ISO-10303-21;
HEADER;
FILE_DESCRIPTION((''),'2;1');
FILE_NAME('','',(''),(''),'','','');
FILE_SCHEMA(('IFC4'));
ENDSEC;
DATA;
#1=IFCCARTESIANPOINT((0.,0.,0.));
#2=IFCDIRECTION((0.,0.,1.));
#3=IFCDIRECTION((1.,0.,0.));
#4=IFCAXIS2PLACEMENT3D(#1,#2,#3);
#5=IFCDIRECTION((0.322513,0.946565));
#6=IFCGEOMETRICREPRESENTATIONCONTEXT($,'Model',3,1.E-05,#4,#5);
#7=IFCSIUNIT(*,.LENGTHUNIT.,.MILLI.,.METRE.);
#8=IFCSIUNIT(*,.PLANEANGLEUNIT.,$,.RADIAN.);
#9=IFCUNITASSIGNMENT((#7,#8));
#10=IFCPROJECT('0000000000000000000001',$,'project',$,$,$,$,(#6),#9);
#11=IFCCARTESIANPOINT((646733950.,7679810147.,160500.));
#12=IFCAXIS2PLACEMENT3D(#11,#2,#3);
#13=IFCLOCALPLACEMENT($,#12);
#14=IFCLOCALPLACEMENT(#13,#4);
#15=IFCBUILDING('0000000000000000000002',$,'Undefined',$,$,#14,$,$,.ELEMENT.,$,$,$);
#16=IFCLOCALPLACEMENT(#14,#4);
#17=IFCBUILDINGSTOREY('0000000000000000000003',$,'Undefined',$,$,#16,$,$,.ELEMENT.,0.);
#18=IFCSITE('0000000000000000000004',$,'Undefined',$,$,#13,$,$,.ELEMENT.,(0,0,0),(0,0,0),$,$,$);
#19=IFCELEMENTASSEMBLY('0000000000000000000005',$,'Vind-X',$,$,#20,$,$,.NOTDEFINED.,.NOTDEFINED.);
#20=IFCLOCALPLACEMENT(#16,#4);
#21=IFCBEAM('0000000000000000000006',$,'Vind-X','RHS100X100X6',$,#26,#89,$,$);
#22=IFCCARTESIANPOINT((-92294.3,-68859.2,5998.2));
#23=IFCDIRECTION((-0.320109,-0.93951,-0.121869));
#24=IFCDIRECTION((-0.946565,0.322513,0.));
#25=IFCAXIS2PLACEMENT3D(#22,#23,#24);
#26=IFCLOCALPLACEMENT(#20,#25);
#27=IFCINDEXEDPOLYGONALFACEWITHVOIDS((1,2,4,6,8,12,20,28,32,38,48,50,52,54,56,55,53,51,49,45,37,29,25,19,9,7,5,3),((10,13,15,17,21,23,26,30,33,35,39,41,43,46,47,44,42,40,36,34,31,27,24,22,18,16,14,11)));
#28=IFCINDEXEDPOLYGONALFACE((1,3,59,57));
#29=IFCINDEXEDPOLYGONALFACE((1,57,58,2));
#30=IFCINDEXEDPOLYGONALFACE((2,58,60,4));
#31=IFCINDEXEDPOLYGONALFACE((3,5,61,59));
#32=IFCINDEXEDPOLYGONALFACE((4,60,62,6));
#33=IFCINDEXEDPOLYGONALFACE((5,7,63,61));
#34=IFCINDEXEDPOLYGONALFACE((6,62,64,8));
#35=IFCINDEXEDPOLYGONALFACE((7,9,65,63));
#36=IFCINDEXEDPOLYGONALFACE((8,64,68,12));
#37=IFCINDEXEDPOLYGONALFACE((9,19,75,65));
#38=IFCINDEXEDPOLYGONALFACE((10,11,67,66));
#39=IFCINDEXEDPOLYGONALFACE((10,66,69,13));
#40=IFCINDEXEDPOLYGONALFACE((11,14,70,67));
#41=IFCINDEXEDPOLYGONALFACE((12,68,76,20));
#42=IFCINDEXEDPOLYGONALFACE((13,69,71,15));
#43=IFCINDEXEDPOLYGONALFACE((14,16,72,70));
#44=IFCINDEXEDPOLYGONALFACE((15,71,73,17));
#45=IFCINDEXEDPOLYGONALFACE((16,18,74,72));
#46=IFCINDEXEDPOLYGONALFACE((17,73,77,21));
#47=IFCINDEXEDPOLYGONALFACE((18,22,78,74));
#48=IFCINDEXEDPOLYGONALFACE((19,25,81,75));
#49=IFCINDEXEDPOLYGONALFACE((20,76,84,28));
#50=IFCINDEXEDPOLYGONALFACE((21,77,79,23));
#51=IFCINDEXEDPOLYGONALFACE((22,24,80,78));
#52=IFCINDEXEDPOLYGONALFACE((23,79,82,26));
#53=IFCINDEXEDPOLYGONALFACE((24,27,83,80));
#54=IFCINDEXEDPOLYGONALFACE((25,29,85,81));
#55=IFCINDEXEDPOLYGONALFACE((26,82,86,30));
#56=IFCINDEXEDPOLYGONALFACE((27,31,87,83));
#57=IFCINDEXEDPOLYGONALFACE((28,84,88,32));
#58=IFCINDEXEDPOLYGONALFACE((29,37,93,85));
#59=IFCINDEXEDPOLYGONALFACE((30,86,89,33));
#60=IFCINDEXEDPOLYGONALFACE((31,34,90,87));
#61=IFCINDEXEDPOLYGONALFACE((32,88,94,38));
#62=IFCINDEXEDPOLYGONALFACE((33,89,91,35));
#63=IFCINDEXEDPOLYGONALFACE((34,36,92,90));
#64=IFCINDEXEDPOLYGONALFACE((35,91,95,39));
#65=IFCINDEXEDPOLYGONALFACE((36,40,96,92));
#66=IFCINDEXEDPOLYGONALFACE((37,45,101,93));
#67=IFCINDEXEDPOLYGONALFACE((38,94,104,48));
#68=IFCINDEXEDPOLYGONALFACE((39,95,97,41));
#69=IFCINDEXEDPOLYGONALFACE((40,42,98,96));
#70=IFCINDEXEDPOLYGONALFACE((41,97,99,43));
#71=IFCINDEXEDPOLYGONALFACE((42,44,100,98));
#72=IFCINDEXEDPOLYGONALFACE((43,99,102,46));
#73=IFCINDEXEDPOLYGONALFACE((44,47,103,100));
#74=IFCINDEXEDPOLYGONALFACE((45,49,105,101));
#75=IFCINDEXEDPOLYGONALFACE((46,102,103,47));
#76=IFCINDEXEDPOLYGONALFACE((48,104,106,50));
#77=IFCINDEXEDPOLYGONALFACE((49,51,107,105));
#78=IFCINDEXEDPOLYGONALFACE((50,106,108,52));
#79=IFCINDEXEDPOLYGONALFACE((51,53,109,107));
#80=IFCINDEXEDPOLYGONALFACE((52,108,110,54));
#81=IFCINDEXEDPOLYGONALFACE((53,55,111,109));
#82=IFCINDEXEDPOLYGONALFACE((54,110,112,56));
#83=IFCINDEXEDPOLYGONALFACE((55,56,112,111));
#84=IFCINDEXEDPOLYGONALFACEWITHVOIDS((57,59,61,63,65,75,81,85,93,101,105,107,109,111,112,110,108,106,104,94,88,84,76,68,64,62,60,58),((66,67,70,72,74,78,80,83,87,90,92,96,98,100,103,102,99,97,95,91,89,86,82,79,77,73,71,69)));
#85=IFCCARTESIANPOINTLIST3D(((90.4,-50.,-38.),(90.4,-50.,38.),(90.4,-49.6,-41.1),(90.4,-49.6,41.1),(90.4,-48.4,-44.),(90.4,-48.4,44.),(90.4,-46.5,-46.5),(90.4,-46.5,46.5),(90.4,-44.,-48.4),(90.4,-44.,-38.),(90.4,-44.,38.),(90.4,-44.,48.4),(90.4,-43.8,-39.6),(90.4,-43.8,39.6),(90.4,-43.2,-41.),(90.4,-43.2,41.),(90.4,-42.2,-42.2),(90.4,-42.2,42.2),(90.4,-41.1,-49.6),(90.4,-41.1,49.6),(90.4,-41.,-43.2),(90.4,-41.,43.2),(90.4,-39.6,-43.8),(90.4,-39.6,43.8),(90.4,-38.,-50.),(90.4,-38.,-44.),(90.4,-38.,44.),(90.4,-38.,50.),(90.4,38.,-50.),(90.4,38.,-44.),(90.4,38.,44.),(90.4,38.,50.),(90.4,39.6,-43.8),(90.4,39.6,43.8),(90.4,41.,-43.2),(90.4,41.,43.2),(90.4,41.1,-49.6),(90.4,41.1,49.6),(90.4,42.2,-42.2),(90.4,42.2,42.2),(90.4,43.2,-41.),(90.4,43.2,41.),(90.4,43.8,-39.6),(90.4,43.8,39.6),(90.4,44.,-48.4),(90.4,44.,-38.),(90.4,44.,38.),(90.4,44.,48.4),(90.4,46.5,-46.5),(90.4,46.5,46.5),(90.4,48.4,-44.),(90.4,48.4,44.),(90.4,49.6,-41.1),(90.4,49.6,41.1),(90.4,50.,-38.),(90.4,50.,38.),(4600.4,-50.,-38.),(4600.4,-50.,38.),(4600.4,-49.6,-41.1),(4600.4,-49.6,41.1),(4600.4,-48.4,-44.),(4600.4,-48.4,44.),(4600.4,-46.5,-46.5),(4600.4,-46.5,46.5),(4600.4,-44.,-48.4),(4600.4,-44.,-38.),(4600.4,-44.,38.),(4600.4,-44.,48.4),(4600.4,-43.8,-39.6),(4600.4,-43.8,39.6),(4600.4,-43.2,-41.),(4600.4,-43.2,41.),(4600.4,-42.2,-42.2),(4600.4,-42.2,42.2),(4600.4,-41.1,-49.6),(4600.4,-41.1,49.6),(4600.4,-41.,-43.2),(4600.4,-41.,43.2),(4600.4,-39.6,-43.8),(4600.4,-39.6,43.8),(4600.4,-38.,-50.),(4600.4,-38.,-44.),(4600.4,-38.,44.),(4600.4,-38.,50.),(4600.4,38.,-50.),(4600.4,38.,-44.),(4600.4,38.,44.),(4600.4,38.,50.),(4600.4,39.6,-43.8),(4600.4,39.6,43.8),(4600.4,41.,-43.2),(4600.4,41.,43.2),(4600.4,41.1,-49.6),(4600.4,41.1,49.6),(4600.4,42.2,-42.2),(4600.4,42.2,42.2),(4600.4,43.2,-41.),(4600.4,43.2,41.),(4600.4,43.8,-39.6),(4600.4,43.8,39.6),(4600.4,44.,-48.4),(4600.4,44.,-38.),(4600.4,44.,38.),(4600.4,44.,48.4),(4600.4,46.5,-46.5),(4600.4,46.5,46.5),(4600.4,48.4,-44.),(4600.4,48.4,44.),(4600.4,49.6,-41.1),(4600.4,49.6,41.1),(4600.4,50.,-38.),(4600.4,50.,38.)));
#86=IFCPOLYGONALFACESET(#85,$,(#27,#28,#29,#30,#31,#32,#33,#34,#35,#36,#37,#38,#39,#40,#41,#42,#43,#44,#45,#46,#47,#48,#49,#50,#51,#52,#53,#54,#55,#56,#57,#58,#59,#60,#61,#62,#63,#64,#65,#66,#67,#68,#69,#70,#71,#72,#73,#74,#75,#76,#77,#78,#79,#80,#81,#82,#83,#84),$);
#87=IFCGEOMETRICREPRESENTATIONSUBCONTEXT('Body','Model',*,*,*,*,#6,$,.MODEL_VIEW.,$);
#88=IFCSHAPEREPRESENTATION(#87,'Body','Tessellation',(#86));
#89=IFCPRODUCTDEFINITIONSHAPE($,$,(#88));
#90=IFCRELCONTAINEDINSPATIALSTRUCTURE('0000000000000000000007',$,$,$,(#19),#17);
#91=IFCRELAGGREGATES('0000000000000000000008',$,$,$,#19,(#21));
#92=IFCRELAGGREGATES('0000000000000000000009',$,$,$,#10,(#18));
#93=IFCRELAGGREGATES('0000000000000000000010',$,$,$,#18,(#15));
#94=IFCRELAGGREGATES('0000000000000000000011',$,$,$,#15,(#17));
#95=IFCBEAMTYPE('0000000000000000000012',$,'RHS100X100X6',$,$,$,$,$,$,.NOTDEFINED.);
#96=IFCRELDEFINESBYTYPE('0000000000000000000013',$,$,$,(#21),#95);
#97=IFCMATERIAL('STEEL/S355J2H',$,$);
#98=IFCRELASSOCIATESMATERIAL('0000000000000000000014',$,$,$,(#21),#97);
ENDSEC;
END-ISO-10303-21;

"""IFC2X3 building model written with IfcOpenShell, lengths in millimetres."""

from ifc_helpers import new_model, si_unit, direction, frame, origin_with_axes, origin_2d_with_axis, place, context, subcontext, project, spatial, hollow_rectangle, extrude, clip, halfspace, material, type_object, element, aggregate, save


model = new_model("IFC2X3")

# Units and contexts
model_context = context("Model", 3, precision=1e-05, world=origin_with_axes(), true_north=direction((0.322513, 0.946565)))
body_context = subcontext(model_context, "Body", "Model", "MODEL_VIEW")
ifc_project = project(units=[si_unit("LENGTHUNIT", "METRE", prefix="MILLI"), si_unit("PLANEANGLEUNIT", "RADIAN")], contexts=[model_context])

# Site, building, storey
site_placement = place(None, frame((646733950.0, 7679810147.0, 160500.0), z_axis=(0.0, 0.0, 1.0), x_axis=(1.0, 0.0, 0.0)))
site = spatial("IfcSite", under=ifc_project, at=site_placement, Name="Undefined", CompositionType="ELEMENT", RefLatitude=(0, 0, 0), RefLongitude=(0, 0, 0))
building_placement = place(site_placement, origin_with_axes())
building = spatial("IfcBuilding", under=site, at=building_placement, Name="Undefined", CompositionType="ELEMENT")
storey_placement = place(building_placement, origin_with_axes())
storey = spatial("IfcBuildingStorey", under=building, at=storey_placement, Name="Undefined", CompositionType="ELEMENT", Elevation=0.0)

# Shared definitions
ifc_material_1 = material(Name="STEEL/S355J2H")

# Element assembly, beam
beam_type = type_object("IfcBeamType", Name="RHS100X100X6", PredefinedType="NOTDEFINED")
assembly_1_placement = place(storey_placement, origin_with_axes())
assembly_1 = element("IfcElementAssembly", 1, at=assembly_1_placement, inside=storey, Name="Vind-X", AssemblyPlace="NOTDEFINED", PredefinedType="NOTDEFINED")
beam_1_placement = place(assembly_1_placement, frame((-92294.3, -68859.2, 5998.2), z_axis=(-0.320109, -0.93951, -0.121869), x_axis=(-0.946565, 0.322513, 0.0)))
beam_1 = element("IfcBeam", 2, at=beam_1_placement, type_object=beam_type, material=ifc_material_1, Name="Vind-X", Description="RHS100X100X6", context=body_context, shape_type="Clipping", body=[
    clip(clip(extrude(hollow_rectangle(XDim=100.0, YDim=100.0, WallThickness=6.0, InnerFilletRadius=6.0, OuterFilletRadius=12.0, at=origin_2d_with_axis()), frame((4690.0, 0.0, 0.0), z_axis=(-1.0, 0.0, 0.0), x_axis=(0.0, -1.0, 0.0)), (0.0, 0.0, 1.0), 4690.0), halfspace(frame((4600.4, 22.5, 0.0), z_axis=(-1.0, 0.0, 0.0), x_axis=(0.0, 0.0, 1.0)), True)), halfspace(frame((90.4, 22.5, 0.0), z_axis=(1.0, 0.0, 0.0), x_axis=(0.0, 0.0, -1.0)), True)),
])

aggregate(assembly_1, [beam_1])

save(model, "model.ifc")
